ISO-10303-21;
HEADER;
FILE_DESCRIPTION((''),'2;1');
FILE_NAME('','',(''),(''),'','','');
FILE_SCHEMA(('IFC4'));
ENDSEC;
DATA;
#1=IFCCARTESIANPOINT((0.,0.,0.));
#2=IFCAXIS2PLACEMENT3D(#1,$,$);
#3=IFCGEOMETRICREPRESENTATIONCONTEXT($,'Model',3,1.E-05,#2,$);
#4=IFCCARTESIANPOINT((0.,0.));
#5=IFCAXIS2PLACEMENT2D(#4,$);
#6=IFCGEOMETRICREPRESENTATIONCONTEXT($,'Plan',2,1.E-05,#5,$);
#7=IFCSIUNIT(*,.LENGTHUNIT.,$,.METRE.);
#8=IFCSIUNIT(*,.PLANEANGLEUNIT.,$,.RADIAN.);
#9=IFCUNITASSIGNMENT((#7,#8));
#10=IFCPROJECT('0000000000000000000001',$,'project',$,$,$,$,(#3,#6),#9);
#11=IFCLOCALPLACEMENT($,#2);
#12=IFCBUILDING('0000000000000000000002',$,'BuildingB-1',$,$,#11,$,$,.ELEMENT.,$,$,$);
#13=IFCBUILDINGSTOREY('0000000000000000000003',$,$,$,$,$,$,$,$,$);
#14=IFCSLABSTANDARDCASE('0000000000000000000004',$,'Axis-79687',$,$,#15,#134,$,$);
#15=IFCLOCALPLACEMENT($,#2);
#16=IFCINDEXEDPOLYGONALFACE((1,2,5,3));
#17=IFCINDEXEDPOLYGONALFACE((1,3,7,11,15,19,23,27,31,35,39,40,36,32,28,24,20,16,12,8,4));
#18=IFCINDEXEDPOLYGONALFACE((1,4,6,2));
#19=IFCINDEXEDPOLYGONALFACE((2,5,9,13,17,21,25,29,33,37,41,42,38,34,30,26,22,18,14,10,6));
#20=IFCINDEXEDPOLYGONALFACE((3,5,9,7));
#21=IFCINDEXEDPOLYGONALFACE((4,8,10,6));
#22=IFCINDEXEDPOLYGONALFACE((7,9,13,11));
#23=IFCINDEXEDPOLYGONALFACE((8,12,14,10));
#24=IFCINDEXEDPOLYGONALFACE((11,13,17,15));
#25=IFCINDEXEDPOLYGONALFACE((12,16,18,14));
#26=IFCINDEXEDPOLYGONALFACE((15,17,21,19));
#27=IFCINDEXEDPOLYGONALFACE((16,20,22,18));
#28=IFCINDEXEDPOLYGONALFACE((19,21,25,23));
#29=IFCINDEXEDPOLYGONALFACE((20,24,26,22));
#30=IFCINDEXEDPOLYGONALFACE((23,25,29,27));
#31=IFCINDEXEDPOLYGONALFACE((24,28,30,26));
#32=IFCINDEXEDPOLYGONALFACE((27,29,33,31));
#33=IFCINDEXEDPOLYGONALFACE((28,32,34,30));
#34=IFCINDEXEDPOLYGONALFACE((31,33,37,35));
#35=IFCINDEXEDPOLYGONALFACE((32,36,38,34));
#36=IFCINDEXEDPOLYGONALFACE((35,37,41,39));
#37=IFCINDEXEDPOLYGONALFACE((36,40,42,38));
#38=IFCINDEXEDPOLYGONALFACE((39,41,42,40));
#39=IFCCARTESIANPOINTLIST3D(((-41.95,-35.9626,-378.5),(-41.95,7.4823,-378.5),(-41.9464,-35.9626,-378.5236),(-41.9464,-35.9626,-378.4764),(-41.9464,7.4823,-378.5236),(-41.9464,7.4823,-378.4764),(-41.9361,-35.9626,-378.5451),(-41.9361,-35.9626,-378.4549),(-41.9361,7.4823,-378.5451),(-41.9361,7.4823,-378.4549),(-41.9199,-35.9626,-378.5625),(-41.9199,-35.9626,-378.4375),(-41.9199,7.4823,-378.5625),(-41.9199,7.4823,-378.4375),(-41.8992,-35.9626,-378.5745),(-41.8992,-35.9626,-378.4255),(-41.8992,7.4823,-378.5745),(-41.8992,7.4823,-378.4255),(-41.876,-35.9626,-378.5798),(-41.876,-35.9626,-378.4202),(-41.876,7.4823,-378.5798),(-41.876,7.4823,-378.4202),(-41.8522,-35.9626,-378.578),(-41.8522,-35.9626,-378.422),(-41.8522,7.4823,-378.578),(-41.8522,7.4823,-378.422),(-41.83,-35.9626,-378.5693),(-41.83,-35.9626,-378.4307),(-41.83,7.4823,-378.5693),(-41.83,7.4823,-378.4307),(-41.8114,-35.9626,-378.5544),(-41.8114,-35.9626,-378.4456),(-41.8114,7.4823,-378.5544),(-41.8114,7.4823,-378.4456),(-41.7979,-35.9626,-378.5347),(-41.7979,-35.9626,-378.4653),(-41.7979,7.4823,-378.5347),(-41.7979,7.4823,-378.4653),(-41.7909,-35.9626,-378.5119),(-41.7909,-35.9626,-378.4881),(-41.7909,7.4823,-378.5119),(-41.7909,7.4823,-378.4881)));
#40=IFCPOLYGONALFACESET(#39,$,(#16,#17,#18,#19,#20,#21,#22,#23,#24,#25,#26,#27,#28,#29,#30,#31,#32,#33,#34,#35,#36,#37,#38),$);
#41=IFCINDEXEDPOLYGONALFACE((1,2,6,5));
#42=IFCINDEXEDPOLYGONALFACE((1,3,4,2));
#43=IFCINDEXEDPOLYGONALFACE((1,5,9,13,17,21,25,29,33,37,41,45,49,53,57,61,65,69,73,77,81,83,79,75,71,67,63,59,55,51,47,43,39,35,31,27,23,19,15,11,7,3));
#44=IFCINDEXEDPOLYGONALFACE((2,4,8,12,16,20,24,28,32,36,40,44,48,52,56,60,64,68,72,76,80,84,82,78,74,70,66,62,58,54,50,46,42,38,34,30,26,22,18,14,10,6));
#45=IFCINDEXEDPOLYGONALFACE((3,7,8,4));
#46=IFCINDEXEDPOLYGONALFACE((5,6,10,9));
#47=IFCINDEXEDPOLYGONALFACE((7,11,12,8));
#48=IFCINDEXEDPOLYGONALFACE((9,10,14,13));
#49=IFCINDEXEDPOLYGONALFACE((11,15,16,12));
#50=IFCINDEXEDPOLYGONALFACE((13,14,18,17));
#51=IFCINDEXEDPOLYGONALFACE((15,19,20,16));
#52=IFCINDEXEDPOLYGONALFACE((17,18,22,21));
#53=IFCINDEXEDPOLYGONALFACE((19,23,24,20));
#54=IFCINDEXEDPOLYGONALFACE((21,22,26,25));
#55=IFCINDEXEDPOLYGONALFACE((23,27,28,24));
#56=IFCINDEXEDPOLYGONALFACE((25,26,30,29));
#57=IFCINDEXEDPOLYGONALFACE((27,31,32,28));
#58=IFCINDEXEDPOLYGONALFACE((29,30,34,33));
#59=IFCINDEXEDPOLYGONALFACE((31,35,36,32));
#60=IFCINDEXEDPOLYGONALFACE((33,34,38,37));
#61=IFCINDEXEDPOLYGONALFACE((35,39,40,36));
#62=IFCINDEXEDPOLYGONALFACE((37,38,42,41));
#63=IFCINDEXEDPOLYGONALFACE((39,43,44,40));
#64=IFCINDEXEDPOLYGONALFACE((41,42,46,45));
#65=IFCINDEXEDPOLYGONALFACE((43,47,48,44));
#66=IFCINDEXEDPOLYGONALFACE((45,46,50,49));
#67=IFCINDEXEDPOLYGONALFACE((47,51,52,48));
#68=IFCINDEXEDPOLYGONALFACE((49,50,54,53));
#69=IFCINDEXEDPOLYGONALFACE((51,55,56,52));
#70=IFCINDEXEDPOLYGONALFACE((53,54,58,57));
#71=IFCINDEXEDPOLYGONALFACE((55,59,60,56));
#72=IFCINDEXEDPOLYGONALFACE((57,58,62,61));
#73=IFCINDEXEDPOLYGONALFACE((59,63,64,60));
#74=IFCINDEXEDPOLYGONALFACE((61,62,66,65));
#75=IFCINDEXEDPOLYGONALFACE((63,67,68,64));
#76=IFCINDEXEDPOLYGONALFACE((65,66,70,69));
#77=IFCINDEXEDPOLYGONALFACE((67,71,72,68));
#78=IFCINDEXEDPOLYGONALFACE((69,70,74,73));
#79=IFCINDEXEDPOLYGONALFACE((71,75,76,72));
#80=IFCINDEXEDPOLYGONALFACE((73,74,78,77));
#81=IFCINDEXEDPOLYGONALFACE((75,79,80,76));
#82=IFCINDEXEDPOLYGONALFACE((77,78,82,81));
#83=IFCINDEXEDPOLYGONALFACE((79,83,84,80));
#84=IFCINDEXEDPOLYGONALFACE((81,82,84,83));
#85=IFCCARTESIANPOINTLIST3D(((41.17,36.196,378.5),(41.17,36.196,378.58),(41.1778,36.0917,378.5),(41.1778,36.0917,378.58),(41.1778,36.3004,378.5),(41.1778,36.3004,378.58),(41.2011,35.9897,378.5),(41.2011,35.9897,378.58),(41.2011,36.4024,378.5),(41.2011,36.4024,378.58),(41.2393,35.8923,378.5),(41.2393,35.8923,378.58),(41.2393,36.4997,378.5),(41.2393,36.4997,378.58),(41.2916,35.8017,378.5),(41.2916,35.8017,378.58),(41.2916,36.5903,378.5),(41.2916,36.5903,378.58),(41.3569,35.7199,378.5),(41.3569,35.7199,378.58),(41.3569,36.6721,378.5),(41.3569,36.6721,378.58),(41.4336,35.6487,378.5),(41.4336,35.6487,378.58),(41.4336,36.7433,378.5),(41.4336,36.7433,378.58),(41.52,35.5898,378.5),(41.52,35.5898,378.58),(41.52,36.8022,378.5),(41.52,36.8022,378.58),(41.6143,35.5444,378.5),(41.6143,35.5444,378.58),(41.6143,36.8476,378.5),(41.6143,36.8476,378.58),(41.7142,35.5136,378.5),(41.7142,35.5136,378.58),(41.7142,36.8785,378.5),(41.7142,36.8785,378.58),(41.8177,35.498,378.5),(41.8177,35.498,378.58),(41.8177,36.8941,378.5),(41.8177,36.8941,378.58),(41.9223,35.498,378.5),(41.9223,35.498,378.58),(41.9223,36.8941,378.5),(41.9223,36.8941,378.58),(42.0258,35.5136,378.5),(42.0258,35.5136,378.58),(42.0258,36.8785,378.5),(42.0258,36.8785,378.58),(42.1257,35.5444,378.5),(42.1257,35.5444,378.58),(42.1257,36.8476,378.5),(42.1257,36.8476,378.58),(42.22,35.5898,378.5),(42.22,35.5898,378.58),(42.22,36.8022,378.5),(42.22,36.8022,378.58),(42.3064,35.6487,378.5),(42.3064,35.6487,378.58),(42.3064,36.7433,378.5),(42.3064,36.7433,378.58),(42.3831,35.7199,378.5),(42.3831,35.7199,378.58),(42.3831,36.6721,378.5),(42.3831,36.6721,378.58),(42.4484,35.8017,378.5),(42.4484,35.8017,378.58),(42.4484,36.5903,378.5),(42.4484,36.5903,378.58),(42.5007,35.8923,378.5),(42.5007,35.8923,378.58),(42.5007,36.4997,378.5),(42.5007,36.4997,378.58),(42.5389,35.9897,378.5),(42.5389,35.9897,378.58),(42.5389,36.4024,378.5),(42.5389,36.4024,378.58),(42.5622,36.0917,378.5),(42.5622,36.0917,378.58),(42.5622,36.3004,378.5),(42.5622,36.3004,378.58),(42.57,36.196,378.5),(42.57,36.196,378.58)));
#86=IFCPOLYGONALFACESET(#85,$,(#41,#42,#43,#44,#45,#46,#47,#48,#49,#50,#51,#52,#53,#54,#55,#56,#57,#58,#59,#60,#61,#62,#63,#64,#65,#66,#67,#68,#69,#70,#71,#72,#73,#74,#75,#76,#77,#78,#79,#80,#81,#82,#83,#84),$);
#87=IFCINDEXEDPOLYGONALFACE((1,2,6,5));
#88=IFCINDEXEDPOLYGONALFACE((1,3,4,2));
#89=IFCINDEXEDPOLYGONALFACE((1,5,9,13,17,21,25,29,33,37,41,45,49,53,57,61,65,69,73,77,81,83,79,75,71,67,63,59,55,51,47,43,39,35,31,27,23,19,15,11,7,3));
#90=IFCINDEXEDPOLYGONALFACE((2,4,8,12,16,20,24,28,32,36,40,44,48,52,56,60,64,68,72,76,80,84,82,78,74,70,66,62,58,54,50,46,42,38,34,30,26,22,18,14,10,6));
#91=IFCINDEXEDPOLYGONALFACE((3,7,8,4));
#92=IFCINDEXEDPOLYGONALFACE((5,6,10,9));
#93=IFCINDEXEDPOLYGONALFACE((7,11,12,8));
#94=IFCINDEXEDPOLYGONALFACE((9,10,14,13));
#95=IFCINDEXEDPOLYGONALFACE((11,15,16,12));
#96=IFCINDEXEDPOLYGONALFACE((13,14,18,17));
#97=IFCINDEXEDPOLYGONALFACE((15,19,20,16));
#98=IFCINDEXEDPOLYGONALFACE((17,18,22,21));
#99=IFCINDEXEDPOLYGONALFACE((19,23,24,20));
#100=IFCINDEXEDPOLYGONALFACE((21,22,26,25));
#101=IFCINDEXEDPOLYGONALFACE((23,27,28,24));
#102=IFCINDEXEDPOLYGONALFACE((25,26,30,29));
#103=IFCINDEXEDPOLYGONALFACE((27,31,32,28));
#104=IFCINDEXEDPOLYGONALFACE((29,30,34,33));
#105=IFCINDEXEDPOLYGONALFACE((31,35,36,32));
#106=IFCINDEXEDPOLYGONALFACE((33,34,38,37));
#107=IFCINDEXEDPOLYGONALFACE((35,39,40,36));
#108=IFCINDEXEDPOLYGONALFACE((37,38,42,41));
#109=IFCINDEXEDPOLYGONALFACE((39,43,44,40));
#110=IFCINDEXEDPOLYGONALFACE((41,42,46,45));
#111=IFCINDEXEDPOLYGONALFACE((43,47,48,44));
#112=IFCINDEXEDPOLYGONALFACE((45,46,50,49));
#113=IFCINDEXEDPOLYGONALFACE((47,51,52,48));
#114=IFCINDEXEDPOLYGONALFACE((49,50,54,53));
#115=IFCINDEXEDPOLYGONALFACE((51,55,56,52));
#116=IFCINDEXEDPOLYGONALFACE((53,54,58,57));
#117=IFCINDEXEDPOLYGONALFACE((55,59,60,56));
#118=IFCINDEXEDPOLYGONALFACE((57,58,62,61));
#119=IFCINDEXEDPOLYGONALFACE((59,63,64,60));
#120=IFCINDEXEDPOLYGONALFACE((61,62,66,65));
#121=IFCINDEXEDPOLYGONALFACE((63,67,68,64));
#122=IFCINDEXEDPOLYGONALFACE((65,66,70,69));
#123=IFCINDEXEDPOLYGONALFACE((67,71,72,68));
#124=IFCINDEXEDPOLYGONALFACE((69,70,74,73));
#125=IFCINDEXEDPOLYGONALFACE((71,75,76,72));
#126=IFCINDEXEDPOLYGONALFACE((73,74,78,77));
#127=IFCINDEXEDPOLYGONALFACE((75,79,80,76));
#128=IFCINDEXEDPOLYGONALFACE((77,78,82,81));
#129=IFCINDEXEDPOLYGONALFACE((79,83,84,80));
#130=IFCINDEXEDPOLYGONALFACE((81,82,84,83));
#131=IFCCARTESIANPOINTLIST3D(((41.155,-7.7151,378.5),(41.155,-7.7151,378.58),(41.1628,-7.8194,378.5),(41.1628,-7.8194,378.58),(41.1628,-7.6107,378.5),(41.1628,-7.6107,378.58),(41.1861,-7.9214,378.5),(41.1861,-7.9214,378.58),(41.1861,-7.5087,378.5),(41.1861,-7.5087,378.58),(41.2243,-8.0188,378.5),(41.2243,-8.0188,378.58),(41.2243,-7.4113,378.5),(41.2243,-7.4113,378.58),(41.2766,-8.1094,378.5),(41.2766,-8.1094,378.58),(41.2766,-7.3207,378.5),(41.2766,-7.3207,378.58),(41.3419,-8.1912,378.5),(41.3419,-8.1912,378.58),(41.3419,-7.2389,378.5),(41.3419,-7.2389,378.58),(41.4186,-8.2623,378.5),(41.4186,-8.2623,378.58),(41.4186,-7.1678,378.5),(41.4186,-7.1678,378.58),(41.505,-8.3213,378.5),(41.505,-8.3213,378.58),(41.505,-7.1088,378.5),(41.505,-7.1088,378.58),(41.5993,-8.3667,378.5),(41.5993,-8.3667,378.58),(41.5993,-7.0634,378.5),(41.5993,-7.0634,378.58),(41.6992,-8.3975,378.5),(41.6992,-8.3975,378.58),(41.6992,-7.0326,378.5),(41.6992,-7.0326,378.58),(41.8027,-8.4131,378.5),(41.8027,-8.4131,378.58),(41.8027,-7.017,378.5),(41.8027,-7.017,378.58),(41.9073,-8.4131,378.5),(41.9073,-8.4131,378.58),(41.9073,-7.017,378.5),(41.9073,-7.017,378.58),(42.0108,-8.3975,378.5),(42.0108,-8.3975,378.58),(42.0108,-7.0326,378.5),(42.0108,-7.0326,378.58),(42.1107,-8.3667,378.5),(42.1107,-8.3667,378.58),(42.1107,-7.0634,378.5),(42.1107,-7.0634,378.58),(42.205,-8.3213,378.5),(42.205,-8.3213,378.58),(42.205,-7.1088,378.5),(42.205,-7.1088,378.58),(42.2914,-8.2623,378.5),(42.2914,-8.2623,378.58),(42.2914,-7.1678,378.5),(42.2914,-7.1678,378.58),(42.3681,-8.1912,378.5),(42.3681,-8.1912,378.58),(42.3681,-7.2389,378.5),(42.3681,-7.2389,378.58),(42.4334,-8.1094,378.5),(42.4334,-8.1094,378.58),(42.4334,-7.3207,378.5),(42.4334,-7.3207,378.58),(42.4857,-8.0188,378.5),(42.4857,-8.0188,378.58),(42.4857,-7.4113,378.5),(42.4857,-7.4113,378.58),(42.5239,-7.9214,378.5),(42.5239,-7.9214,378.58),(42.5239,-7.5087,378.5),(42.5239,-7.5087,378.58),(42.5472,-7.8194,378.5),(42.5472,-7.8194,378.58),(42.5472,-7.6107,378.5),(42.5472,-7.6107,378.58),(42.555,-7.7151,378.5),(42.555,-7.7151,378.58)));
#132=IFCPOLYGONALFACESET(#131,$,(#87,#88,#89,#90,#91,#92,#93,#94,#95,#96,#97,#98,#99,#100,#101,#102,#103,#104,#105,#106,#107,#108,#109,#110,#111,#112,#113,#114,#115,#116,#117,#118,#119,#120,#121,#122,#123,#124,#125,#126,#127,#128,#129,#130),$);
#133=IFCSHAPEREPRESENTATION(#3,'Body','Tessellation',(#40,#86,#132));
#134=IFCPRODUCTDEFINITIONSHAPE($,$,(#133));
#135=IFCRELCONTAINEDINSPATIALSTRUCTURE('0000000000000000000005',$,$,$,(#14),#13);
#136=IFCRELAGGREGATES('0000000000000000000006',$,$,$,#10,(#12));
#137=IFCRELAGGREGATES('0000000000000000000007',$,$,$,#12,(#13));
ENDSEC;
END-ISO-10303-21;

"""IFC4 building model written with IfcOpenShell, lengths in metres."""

from ifc_helpers import new_model, entity, si_unit, frame, origin, origin_2d, place, context, project, spatial, circle, extrude, element, save


model = new_model("IFC4")

# Units and contexts
model_context = context("Model", 3, precision=1e-05, world=origin())
plan_context = context("Plan", 2, precision=1e-05, world=origin_2d())
ifc_project = project(units=[si_unit("LENGTHUNIT", "METRE"), si_unit("PLANEANGLEUNIT", "RADIAN")], contexts=[model_context, plan_context])

# Building, storey
building_placement = place(None, origin())
building = spatial("IfcBuilding", under=ifc_project, at=building_placement, Name="BuildingB-1", CompositionType="ELEMENT")
storey = spatial("IfcBuildingStorey", under=building)

# Slab
element("IfcSlabStandardCase", 1, inside=storey, Name="Axis-79687", context=model_context, shape_type="AdvancedSweptSolid", body=[
    entity("IfcSurfaceCurveSweptAreaSolid", entity("IfcCircleProfileDef", "AREA", None, None, 0.08), None, entity("IfcPolyline", [entity("IfcCartesianPoint", [41.87, 35.9626, 378.5]), entity("IfcCartesianPoint", [41.87, -7.4823, 378.5])]), None, None, entity("IfcPlane", entity("IfcAxis2Placement3D", entity("IfcCartesianPoint", [41.87, 35.9626, 378.5]), entity("IfcDirection", [0.0, 0.0, 1.0]), entity("IfcDirection", [1.0, 0.0, 0.0])))),
    extrude(circle(Radius=0.7), frame((41.87, 36.196, 378.5)), (0.0, 0.0, 1.0), 0.08),
    extrude(circle(Radius=0.7), frame((41.855, -7.7151, 378.5)), (0.0, 0.0, 1.0), 0.08),
])

save(model, "model.ifc")
